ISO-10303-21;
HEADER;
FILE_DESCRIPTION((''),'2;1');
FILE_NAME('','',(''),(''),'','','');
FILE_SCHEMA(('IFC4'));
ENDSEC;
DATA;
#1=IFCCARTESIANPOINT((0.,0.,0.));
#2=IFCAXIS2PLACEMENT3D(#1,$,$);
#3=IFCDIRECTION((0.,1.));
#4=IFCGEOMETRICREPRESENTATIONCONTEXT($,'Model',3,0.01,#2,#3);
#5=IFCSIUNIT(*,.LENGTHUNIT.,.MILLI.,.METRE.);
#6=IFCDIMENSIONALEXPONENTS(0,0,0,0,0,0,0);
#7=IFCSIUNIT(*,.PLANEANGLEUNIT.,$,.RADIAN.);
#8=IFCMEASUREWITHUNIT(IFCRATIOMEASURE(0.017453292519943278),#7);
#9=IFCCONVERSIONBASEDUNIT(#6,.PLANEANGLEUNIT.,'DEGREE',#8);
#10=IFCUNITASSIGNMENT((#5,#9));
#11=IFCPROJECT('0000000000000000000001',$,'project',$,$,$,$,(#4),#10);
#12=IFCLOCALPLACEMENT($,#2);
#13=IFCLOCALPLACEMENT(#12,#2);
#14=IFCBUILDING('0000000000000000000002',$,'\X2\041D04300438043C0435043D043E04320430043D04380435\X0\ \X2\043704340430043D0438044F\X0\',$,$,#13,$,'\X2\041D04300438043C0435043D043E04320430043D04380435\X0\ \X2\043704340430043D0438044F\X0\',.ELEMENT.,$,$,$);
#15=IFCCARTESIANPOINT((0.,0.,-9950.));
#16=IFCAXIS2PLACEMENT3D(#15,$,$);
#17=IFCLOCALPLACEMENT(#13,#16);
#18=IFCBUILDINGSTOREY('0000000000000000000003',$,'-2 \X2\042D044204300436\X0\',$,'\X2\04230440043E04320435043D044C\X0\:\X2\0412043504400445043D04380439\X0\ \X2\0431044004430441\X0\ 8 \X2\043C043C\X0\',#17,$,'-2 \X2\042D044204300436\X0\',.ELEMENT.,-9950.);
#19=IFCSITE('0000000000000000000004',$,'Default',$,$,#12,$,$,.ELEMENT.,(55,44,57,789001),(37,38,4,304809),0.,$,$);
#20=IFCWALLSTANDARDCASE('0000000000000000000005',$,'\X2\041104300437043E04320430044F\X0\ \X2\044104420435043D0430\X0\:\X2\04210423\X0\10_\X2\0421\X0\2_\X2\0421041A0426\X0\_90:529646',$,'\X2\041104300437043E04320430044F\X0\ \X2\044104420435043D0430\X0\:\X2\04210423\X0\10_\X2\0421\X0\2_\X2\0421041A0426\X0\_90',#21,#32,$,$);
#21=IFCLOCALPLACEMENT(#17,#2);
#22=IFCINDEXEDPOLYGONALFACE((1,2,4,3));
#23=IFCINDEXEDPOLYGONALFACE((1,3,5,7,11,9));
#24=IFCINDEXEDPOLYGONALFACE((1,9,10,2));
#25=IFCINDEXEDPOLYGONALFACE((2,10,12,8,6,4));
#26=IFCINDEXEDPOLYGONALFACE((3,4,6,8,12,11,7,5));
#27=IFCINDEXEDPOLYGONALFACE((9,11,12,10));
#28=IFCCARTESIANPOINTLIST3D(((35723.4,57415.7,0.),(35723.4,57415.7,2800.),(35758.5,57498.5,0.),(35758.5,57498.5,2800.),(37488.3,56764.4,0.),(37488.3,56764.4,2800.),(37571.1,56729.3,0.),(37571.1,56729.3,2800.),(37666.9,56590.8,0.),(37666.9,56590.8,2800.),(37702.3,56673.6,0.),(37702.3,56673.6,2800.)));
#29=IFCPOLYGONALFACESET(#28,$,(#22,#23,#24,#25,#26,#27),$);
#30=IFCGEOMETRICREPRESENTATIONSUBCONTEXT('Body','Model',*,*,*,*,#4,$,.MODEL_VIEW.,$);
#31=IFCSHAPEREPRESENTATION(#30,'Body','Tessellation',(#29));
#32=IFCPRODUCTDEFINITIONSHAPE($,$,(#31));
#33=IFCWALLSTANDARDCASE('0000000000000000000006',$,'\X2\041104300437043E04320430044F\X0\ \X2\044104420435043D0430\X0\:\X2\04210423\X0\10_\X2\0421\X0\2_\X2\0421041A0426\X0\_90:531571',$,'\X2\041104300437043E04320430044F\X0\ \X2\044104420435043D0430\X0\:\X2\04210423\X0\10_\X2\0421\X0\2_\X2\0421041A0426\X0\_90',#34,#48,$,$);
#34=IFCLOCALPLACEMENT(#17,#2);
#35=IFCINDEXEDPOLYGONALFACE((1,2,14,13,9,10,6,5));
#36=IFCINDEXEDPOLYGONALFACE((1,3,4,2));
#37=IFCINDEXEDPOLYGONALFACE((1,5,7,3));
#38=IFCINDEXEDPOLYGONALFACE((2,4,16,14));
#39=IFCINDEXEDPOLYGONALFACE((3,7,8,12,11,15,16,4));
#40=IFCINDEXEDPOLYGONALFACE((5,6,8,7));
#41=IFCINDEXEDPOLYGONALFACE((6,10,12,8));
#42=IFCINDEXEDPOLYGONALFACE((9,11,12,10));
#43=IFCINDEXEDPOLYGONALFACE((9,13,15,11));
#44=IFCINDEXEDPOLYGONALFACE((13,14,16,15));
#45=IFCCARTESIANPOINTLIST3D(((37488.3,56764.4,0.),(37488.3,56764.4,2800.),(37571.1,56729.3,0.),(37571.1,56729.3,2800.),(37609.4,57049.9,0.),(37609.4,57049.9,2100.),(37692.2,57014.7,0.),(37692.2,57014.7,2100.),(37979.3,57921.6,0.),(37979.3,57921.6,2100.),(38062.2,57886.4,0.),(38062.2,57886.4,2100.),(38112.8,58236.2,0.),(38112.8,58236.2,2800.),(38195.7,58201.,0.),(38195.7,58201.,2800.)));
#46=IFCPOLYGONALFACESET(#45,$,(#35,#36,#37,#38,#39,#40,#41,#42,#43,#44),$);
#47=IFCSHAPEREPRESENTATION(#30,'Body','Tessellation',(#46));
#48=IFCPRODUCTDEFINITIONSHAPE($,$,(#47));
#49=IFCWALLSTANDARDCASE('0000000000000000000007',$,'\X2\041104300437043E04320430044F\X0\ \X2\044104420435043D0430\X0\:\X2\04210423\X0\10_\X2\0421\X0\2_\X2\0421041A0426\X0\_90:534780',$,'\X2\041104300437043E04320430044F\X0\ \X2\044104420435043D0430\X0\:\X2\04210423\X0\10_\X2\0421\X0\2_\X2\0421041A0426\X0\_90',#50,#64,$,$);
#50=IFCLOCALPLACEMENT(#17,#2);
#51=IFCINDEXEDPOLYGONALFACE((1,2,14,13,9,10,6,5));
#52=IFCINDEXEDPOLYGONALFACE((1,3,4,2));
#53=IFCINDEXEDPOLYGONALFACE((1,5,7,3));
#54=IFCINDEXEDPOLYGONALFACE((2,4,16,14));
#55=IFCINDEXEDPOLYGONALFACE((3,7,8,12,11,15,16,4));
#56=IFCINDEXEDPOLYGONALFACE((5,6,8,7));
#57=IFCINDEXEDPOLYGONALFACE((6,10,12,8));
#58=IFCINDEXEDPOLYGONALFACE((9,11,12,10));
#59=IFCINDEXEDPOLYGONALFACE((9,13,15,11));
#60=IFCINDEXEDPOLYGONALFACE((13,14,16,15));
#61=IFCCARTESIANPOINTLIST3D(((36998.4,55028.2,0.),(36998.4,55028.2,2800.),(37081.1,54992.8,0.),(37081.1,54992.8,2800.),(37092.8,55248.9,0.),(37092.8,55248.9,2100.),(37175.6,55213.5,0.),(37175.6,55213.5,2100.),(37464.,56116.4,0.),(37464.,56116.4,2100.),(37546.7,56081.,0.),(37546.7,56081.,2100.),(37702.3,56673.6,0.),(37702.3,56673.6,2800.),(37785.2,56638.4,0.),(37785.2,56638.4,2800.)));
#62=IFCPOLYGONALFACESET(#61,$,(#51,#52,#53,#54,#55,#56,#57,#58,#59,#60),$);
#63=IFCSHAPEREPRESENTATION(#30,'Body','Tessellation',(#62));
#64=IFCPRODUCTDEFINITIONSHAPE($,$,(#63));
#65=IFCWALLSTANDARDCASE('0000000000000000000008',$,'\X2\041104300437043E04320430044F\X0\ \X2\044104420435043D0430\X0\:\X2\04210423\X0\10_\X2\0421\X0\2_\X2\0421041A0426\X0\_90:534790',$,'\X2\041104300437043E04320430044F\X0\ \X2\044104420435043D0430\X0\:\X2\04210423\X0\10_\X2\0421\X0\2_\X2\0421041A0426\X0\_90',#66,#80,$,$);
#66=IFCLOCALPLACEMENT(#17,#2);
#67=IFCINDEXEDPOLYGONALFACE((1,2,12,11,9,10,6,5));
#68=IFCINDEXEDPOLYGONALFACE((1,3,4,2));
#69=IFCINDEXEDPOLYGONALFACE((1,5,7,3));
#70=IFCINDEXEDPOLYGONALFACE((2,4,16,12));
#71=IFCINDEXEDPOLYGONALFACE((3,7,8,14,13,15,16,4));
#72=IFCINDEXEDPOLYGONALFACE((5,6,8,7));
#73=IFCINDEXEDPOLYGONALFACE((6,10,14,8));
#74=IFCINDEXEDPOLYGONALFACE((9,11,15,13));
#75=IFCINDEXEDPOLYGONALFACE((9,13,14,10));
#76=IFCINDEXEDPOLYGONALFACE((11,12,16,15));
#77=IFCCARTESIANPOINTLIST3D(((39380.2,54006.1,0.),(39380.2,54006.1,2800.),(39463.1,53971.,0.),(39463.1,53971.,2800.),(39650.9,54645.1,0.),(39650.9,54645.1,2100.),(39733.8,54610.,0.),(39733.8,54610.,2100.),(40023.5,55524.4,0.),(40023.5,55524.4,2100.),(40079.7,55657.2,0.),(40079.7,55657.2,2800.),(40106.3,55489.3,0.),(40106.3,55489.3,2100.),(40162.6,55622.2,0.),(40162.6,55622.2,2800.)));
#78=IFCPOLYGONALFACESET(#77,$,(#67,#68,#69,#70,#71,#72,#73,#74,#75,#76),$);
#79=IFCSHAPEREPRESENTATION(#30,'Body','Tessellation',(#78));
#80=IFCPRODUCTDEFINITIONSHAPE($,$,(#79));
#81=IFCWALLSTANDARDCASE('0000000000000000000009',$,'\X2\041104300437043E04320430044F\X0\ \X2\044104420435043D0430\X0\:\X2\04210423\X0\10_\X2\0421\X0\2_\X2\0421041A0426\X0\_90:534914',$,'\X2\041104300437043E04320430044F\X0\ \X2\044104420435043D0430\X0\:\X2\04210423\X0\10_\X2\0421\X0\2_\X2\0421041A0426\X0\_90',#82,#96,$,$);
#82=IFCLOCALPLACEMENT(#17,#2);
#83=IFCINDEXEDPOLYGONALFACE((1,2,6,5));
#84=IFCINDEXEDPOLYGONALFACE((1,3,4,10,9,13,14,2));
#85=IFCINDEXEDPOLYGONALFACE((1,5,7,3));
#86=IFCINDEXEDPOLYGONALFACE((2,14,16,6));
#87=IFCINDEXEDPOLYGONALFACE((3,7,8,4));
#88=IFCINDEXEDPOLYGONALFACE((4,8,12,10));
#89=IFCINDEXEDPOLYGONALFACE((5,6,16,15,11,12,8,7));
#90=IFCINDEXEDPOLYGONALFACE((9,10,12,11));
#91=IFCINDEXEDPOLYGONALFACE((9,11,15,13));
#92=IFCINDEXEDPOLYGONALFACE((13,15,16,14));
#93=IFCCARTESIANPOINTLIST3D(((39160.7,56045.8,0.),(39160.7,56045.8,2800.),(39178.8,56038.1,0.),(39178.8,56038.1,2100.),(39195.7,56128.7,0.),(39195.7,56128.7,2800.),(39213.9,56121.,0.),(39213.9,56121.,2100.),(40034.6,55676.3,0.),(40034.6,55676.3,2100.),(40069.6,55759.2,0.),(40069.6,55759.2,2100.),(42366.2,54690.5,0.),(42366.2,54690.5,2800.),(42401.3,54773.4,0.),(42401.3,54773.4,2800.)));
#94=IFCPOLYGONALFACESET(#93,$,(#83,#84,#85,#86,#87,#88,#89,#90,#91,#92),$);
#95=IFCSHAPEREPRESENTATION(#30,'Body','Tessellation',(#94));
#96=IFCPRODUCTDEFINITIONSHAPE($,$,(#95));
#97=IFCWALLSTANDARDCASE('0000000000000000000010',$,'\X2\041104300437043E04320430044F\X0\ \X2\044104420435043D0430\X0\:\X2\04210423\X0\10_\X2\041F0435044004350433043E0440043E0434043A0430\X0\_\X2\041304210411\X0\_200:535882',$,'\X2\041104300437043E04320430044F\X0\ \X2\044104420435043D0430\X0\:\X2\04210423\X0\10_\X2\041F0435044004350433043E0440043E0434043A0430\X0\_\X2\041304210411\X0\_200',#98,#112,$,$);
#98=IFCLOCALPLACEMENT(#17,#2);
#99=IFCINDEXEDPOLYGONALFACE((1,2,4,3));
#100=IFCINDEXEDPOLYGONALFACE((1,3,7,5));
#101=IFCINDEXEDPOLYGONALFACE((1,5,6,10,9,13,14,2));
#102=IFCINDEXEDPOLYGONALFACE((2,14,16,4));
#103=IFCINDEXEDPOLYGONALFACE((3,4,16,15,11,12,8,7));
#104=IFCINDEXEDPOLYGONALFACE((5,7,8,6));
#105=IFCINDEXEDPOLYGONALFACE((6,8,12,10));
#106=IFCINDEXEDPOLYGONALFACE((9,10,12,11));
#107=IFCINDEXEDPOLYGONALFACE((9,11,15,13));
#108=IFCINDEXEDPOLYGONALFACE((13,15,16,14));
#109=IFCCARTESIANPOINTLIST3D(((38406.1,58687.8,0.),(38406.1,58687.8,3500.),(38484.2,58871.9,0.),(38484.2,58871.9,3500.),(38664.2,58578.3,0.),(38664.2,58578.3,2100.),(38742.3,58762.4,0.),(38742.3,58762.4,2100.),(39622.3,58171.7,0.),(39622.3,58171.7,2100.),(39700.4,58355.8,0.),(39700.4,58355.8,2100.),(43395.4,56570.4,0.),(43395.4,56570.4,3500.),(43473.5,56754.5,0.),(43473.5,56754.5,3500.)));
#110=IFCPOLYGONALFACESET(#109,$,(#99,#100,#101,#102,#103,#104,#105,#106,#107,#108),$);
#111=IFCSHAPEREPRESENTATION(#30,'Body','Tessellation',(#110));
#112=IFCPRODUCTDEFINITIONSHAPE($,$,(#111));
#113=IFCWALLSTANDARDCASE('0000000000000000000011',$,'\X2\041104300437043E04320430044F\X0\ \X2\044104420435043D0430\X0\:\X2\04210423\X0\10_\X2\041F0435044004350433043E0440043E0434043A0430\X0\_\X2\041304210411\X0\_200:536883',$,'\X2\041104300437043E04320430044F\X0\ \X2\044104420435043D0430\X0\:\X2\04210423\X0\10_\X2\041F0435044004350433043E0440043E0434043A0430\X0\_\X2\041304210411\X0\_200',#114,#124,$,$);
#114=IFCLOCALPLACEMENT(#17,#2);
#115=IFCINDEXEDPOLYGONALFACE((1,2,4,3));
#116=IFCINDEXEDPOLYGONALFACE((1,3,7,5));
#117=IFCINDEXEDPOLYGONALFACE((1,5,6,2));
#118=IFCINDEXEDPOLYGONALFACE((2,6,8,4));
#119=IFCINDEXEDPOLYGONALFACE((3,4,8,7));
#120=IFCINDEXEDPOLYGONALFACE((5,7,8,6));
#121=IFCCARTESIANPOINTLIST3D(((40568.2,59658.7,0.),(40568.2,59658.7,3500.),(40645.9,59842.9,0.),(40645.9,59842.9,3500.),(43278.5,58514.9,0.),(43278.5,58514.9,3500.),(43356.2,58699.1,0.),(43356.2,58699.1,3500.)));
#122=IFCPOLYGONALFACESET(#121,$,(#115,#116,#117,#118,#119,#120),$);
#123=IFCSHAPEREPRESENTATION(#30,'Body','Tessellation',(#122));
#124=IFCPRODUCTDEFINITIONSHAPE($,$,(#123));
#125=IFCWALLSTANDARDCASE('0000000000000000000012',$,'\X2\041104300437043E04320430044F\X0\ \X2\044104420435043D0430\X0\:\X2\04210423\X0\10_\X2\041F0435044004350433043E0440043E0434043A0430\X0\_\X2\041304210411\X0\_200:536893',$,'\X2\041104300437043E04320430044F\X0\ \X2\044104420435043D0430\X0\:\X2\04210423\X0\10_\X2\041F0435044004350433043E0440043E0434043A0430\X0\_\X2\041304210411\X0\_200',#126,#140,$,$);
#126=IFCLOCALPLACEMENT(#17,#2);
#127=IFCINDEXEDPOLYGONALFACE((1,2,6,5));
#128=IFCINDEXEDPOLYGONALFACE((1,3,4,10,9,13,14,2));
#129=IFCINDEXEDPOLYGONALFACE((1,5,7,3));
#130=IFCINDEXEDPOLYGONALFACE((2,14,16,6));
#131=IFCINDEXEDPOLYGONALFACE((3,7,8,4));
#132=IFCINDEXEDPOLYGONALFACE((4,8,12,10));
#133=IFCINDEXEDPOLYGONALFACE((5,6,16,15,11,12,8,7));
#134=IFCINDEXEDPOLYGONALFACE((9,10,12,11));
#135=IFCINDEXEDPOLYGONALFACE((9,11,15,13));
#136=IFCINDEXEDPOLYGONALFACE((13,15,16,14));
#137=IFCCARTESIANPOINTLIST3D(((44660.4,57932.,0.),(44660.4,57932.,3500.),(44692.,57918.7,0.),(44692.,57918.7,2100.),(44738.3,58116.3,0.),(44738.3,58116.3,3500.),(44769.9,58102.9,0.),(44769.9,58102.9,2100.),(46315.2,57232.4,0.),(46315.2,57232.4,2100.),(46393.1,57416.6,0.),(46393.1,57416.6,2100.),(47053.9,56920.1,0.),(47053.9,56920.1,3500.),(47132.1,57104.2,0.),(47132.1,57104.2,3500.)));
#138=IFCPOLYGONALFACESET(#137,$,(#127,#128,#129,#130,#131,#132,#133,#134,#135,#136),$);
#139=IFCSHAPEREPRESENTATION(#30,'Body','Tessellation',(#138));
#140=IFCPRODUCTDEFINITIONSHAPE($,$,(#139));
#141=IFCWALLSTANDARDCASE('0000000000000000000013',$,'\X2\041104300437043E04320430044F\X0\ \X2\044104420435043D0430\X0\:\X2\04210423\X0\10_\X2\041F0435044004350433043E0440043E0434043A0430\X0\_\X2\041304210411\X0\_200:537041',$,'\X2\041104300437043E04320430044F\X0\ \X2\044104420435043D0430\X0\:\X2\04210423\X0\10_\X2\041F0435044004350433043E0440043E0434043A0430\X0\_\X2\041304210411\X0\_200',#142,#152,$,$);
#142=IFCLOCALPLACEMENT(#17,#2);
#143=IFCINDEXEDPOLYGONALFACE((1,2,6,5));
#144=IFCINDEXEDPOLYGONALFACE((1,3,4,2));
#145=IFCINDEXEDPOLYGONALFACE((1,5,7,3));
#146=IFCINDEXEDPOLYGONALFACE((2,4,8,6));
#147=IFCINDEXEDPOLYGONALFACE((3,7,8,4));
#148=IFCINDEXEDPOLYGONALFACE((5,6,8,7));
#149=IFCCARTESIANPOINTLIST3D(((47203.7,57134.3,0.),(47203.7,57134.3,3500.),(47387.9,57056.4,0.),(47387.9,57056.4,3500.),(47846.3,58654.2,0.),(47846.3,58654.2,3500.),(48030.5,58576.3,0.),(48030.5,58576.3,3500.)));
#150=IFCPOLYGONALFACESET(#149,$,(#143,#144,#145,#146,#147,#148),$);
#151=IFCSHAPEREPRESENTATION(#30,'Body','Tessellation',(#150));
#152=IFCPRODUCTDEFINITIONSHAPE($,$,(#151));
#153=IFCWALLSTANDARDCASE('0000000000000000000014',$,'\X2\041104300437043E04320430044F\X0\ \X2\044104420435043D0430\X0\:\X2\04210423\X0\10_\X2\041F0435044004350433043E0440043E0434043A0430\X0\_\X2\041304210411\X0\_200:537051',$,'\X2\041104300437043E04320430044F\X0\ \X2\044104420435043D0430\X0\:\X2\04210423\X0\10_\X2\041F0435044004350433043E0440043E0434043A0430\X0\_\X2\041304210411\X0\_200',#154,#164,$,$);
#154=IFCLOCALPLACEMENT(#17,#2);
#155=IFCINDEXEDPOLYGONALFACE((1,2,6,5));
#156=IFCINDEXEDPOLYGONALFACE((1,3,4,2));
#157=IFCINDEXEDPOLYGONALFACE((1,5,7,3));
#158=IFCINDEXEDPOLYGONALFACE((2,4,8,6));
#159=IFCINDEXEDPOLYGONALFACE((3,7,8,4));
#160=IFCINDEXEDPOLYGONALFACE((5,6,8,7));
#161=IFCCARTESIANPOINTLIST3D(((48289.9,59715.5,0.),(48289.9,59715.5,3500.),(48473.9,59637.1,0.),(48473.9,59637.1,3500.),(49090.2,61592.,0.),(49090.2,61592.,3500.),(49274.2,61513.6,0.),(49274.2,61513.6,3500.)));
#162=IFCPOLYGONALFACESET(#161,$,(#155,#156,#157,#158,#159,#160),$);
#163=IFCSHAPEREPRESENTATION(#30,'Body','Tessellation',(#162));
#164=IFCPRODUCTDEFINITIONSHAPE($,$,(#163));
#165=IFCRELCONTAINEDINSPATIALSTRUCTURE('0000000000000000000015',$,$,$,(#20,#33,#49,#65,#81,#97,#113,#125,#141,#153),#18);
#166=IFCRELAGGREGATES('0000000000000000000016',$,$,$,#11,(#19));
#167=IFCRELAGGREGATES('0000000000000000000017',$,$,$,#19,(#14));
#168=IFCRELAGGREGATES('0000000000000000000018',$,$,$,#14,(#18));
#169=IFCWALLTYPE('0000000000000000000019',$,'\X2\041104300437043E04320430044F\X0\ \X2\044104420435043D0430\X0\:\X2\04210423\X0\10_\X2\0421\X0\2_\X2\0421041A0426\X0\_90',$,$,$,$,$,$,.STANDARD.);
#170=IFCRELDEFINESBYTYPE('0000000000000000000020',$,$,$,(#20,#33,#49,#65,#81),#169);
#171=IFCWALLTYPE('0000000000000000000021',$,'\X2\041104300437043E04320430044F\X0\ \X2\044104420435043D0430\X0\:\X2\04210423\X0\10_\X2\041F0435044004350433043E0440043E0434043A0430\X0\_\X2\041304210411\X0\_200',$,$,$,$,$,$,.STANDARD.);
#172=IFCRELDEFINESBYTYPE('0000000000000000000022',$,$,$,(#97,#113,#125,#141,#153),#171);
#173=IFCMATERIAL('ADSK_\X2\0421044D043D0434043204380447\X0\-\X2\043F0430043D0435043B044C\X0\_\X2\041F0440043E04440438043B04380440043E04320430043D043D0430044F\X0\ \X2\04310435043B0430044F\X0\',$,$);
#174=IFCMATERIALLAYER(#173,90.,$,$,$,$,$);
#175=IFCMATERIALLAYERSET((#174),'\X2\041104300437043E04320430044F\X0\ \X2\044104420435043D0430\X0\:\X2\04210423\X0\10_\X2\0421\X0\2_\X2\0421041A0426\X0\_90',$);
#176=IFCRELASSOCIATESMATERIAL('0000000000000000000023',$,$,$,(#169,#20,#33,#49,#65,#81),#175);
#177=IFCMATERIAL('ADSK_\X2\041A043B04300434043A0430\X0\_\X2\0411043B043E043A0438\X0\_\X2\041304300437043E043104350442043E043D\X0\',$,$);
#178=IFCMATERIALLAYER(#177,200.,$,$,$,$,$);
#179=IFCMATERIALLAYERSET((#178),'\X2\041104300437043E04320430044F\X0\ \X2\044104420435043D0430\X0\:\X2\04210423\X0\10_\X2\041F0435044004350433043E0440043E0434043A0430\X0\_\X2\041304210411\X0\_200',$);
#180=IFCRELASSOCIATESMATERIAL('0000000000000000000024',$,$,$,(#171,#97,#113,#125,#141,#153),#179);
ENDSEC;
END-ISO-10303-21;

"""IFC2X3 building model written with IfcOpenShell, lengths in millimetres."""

from ifc_helpers import new_model, entity, si_unit, converted_unit, direction, frame, frame_2d, origin, place, context, subcontext, project, spatial, polyline, rectangle, outline, extrude, material, layer, layer_set, layer_usage, type_object, element, save


model = new_model("IFC2X3")

# Units and contexts
model_context = context("Model", 3, precision=0.01, world=origin(), true_north=direction((0.0, 1.0)))
body_context = subcontext(model_context, "Body", "Model", "MODEL_VIEW")
ifc_project = project(units=[si_unit("LENGTHUNIT", "METRE", prefix="MILLI"), converted_unit("PLANEANGLEUNIT", "DEGREE", entity("IfcRatioMeasure", 0.017453292519943278), si_unit("PLANEANGLEUNIT", "RADIAN"), dimensions=[0, 0, 0, 0, 0, 0, 0])], contexts=[model_context])

# Site, building, storey
site_placement = place(None, origin())
site = spatial("IfcSite", under=ifc_project, at=site_placement, Name="Default", CompositionType="ELEMENT", RefLatitude=(55, 44, 57, 789001), RefLongitude=(37, 38, 4, 304809), RefElevation=0.0)
building_placement = place(site_placement, origin())
building = spatial("IfcBuilding", under=site, at=building_placement, Name="Наименование здания", LongName="Наименование здания", CompositionType="ELEMENT")
storey_placement = place(building_placement, frame((0.0, 0.0, -9950.0)))
storey = spatial("IfcBuildingStorey", under=building, at=storey_placement, Name="-2 Этаж", ObjectType="Уровень:Верхний брус 8 мм", LongName="-2 Этаж", CompositionType="ELEMENT", Elevation=-9950.0)

# Wall
ifc_material_1 = material(Name="ADSK_Сэндвич-панель_Профилированная белая")
ifc_layer_1 = layer(ifc_material_1, 90.0)
ifc_layer_set_1 = layer_set([ifc_layer_1], Name="Базовая стена:СУ10_С2_СКЦ_90")
ifc_layer_usage_1 = layer_usage(ifc_layer_set_1, "AXIS2", "NEGATIVE", 45.0)
wall_type_1 = type_object("IfcWallType", Name="Базовая стена:СУ10_С2_СКЦ_90", PredefinedType="STANDARD", material=ifc_layer_set_1)
wall_1_placement = place(storey_placement, frame((37684.8, 56632.2, 0.0), z_axis=(0.0, 0.0, 1.0), x_axis=(-0.920533, 0.390665, 0.0)))
element("IfcWallStandardCase", 1, at=wall_1_placement, inside=storey, type_object=wall_type_1, material=ifc_layer_usage_1, Name="Базовая стена:СУ10_С2_СКЦ_90:529646", ObjectType="Базовая стена:СУ10_С2_СКЦ_90", context=body_context, shape_type="SweptSolid", body=[
    extrude(outline(polyline([(2111.6, -45.0), (2111.6, 45.0), (0.3, 45.0), (0.0, -45.0), (142.6, -45.0), (232.6, -45.0), (2111.6, -45.0)])), origin(), (0.0, 0.0, 1.0), 2800.0),
])

# Walls, openings
wall_2_placement = place(storey_placement, frame((38154.3, 58218.6, 0.0), z_axis=(0.0, 0.0, 1.0), x_axis=(-0.390665, -0.920533, 0.0)))
wall_2 = element("IfcWallStandardCase", 2, at=wall_2_placement, inside=storey, type_object=wall_type_1, material=ifc_layer_usage_1, Name="Базовая стена:СУ10_С2_СКЦ_90:531571", ObjectType="Базовая стена:СУ10_С2_СКЦ_90", context=body_context, shape_type="SweptSolid", body=[
    extrude(rectangle(XDim=1598.8, YDim=90.0, at=frame_2d((799.4, 0.0), x_axis=(-1.0, 0.0))), origin(), (0.0, 0.0, 1.0), 2800.0),
])
opening_1_placement = place(wall_2_placement, origin())
element("IfcOpeningElement", 3, at=opening_1_placement, cuts=wall_2, ObjectType="Opening", context=body_context, shape_type="SweptSolid", body=[
    extrude(rectangle(XDim=2100.0, YDim=947.0, at=frame_2d((0.0, 0.0), x_axis=(1.0, 0.0))), frame((815.2, -45.0, 1050.0), z_axis=(0.0, 1.0, 0.0), x_axis=(0.0, 0.0, -1.0)), (0.0, 0.0, 1.0), 90.0),
])
wall_3_placement = place(storey_placement, frame((37743.8, 56656.1, 0.0), z_axis=(0.0, 0.0, 1.0), x_axis=(-0.393347, -0.91939, 0.0)))
wall_3 = element("IfcWallStandardCase", 4, at=wall_3_placement, inside=storey, type_object=wall_type_1, material=ifc_layer_usage_1, Name="Базовая стена:СУ10_С2_СКЦ_90:534780", ObjectType="Базовая стена:СУ10_С2_СКЦ_90", context=body_context, shape_type="SweptSolid", body=[
    extrude(outline(polyline([(0.3, -45.0), (90.3, -45.0), (1789.9, -45.0), (1789.9, 45.0), (0.0, 45.0), (0.3, -45.0)])), origin(), (0.0, 0.0, 1.0), 2800.0),
])
opening_2_placement = place(wall_3_placement, origin())
element("IfcOpeningElement", 5, at=opening_2_placement, cuts=wall_3, ObjectType="Opening", context=body_context, shape_type="SweptSolid", body=[
    extrude(rectangle(XDim=2100.0, YDim=943.5, at=frame_2d((0.0, 0.0), x_axis=(1.0, 0.0))), frame((1078.1, -45.0, 1050.0), z_axis=(0.0, 1.0, 0.0), x_axis=(0.0, 0.0, -1.0)), (0.0, 0.0, 1.0), 90.0),
])
wall_4_placement = place(storey_placement, frame((40121.2, 55639.7, 0.0), z_axis=(0.0, 0.0, 1.0), x_axis=(-0.390099, -0.920773, 0.0)))
wall_4 = element("IfcWallStandardCase", 6, at=wall_4_placement, inside=storey, type_object=wall_type_1, material=ifc_layer_usage_1, Name="Базовая стена:СУ10_С2_СКЦ_90:534790", ObjectType="Базовая стена:СУ10_С2_СКЦ_90", context=body_context, shape_type="SweptSolid", body=[
    extrude(outline(polyline([(0.1, -45.0), (1793.2, -45.0), (1793.3, 45.0), (0.0, 45.0), (0.1, -45.0)])), origin(), (0.0, 0.0, 1.0), 2800.0),
])
opening_3_placement = place(wall_4_placement, origin())
element("IfcOpeningElement", 7, at=opening_3_placement, cuts=wall_4, ObjectType="Opening", context=body_context, shape_type="SweptSolid", body=[
    extrude(rectangle(XDim=2100.0, YDim=954.9, at=frame_2d((0.0, 0.0), x_axis=(1.0, 0.0))), frame((621.8, -45.0, 1050.0), z_axis=(0.0, 1.0, 0.0), x_axis=(0.0, 0.0, -1.0)), (0.0, 0.0, 1.0), 90.0),
])
wall_5_placement = place(storey_placement, frame((42383.7, 54732.0, 0.0), z_axis=(0.0, 0.0, 1.0), x_axis=(-0.921062, 0.389417, 0.0)))
wall_5 = element("IfcWallStandardCase", 8, at=wall_5_placement, inside=storey, type_object=wall_type_1, material=ifc_layer_usage_1, Name="Базовая стена:СУ10_С2_СКЦ_90:534914", ObjectType="Базовая стена:СУ10_С2_СКЦ_90", context=body_context, shape_type="SweptSolid", body=[
    extrude(rectangle(XDim=3480.2, YDim=90.0, at=frame_2d((1740.1, 0.0), x_axis=(1.0, 0.0))), origin(), (0.0, 0.0, 1.0), 2800.0),
])
opening_4_placement = place(wall_5_placement, origin())
element("IfcOpeningElement", 9, at=opening_4_placement, cuts=wall_5, ObjectType="Opening", context=body_context, shape_type="SweptSolid", body=[
    extrude(rectangle(XDim=2100.0, YDim=929.1, at=frame_2d((0.0, 0.0), x_axis=(1.0, 0.0))), frame((2996.0, -45.0, 1050.0), z_axis=(0.0, 1.0, 0.0), x_axis=(0.0, 0.0, -1.0)), (0.0, 0.0, 1.0), 90.0),
])
ifc_material_2 = material(Name="ADSK_Кладка_Блоки_Газобетон")
ifc_layer_2 = layer(ifc_material_2, 200.0)
ifc_layer_set_2 = layer_set([ifc_layer_2], Name="Базовая стена:СУ10_Перегородка_ГСБ_200")
ifc_layer_usage_2 = layer_usage(ifc_layer_set_2, "AXIS2", "NEGATIVE", 100.0)
wall_type_2 = type_object("IfcWallType", Name="Базовая стена:СУ10_Перегородка_ГСБ_200", PredefinedType="STANDARD", material=ifc_layer_set_2)
wall_6_placement = place(storey_placement, frame((43434.4, 56662.4, 0.0), z_axis=(0.0, 0.0, 1.0), x_axis=(-0.920533, 0.390665, 0.0)))
wall_6 = element("IfcWallStandardCase", 10, at=wall_6_placement, inside=storey, type_object=wall_type_2, material=ifc_layer_usage_2, Name="Базовая стена:СУ10_Перегородка_ГСБ_200:535882", ObjectType="Базовая стена:СУ10_Перегородка_ГСБ_200", context=body_context, shape_type="SweptSolid", body=[
    extrude(rectangle(XDim=5420.0, YDim=200.0, at=frame_2d((2710.0, 0.0), x_axis=(1.0, 0.0))), origin(), (0.0, 0.0, 1.0), 3500.0),
])
opening_5_placement = place(wall_6_placement, origin())
element("IfcOpeningElement", 11, at=opening_5_placement, cuts=wall_6, ObjectType="Opening", context=body_context, shape_type="SweptSolid", body=[
    extrude(rectangle(XDim=2100.0, YDim=1040.8, at=frame_2d((0.0, 0.0), x_axis=(1.0, 0.0))), frame((4619.2, -100.0, 1050.0), z_axis=(0.0, 1.0, 0.0), x_axis=(0.0, 0.0, -1.0)), (0.0, 0.0, 1.0), 200.0),
])

# Wall
wall_7_placement = place(storey_placement, frame((43317.3, 58607.0, 0.0), z_axis=(0.0, 0.0, 1.0), x_axis=(-0.921313, 0.388823, 0.0)))
element("IfcWallStandardCase", 12, at=wall_7_placement, inside=storey, type_object=wall_type_2, material=ifc_layer_usage_2, Name="Базовая стена:СУ10_Перегородка_ГСБ_200:536883", ObjectType="Базовая стена:СУ10_Перегородка_ГСБ_200", context=body_context, shape_type="SweptSolid", body=[
    extrude(rectangle(XDim=2941.8, YDim=200.0, at=frame_2d((1470.9, 0.0), x_axis=(-1.0, 0.0))), origin(), (0.0, 0.0, 1.0), 3500.0),
])

# Wall, opening
wall_8_placement = place(storey_placement, frame((47093.1, 57012.1, 0.0), z_axis=(0.0, 0.0, 1.0), x_axis=(-0.921062, 0.389417, 0.0)))
wall_8 = element("IfcWallStandardCase", 13, at=wall_8_placement, inside=storey, type_object=wall_type_2, material=ifc_layer_usage_2, Name="Базовая стена:СУ10_Перегородка_ГСБ_200:536893", ObjectType="Базовая стена:СУ10_Перегородка_ГСБ_200", context=body_context, shape_type="SweptSolid", body=[
    extrude(outline(polyline([(0.0, -100.0), (2598.9, -100.0), (2598.9, 100.0), (0.3, 100.0), (0.0, -100.0)])), origin(), (0.0, 0.0, 1.0), 3500.0),
])
opening_6_placement = place(wall_8_placement, origin())
element("IfcOpeningElement", 14, at=opening_6_placement, cuts=wall_8, ObjectType="Opening", context=body_context, shape_type="SweptSolid", body=[
    extrude(rectangle(XDim=2100.0, YDim=1762.3, at=frame_2d((0.0, 0.0), x_axis=(1.0, 0.0))), frame((1683.5, -100.0, 1050.0), z_axis=(0.0, 1.0, 0.0), x_axis=(0.0, 0.0, -1.0)), (0.0, 0.0, 1.0), 200.0),
])

# Walls
wall_9_placement = place(storey_placement, frame((47295.8, 57095.4, 0.0), z_axis=(0.0, 0.0, 1.0), x_axis=(0.389429, 0.921057, 0.0)))
element("IfcWallStandardCase", 15, at=wall_9_placement, inside=storey, type_object=wall_type_2, material=ifc_layer_usage_2, Name="Базовая стена:СУ10_Перегородка_ГСБ_200:537041", ObjectType="Базовая стена:СУ10_Перегородка_ГСБ_200", context=body_context, shape_type="SweptSolid", body=[
    extrude(rectangle(XDim=1650.1, YDim=200.0, at=frame_2d((825.1, 0.0), x_axis=(-1.0, 0.0))), origin(), (0.0, 0.0, 1.0), 3500.0),
])
wall_10_placement = place(storey_placement, frame((48381.9, 59676.3, 0.0), z_axis=(0.0, 0.0, 1.0), x_axis=(0.3923, 0.919837, 0.0)))
element("IfcWallStandardCase", 16, at=wall_10_placement, inside=storey, type_object=wall_type_2, material=ifc_layer_usage_2, Name="Базовая стена:СУ10_Перегородка_ГСБ_200:537051", ObjectType="Базовая стена:СУ10_Перегородка_ГСБ_200", context=body_context, shape_type="SweptSolid", body=[
    extrude(rectangle(XDim=2040.0, YDim=200.0, at=frame_2d((1020.0, 0.0), x_axis=(-1.0, 0.0))), origin(), (0.0, 0.0, 1.0), 3500.0),
])

save(model, "model.ifc")
